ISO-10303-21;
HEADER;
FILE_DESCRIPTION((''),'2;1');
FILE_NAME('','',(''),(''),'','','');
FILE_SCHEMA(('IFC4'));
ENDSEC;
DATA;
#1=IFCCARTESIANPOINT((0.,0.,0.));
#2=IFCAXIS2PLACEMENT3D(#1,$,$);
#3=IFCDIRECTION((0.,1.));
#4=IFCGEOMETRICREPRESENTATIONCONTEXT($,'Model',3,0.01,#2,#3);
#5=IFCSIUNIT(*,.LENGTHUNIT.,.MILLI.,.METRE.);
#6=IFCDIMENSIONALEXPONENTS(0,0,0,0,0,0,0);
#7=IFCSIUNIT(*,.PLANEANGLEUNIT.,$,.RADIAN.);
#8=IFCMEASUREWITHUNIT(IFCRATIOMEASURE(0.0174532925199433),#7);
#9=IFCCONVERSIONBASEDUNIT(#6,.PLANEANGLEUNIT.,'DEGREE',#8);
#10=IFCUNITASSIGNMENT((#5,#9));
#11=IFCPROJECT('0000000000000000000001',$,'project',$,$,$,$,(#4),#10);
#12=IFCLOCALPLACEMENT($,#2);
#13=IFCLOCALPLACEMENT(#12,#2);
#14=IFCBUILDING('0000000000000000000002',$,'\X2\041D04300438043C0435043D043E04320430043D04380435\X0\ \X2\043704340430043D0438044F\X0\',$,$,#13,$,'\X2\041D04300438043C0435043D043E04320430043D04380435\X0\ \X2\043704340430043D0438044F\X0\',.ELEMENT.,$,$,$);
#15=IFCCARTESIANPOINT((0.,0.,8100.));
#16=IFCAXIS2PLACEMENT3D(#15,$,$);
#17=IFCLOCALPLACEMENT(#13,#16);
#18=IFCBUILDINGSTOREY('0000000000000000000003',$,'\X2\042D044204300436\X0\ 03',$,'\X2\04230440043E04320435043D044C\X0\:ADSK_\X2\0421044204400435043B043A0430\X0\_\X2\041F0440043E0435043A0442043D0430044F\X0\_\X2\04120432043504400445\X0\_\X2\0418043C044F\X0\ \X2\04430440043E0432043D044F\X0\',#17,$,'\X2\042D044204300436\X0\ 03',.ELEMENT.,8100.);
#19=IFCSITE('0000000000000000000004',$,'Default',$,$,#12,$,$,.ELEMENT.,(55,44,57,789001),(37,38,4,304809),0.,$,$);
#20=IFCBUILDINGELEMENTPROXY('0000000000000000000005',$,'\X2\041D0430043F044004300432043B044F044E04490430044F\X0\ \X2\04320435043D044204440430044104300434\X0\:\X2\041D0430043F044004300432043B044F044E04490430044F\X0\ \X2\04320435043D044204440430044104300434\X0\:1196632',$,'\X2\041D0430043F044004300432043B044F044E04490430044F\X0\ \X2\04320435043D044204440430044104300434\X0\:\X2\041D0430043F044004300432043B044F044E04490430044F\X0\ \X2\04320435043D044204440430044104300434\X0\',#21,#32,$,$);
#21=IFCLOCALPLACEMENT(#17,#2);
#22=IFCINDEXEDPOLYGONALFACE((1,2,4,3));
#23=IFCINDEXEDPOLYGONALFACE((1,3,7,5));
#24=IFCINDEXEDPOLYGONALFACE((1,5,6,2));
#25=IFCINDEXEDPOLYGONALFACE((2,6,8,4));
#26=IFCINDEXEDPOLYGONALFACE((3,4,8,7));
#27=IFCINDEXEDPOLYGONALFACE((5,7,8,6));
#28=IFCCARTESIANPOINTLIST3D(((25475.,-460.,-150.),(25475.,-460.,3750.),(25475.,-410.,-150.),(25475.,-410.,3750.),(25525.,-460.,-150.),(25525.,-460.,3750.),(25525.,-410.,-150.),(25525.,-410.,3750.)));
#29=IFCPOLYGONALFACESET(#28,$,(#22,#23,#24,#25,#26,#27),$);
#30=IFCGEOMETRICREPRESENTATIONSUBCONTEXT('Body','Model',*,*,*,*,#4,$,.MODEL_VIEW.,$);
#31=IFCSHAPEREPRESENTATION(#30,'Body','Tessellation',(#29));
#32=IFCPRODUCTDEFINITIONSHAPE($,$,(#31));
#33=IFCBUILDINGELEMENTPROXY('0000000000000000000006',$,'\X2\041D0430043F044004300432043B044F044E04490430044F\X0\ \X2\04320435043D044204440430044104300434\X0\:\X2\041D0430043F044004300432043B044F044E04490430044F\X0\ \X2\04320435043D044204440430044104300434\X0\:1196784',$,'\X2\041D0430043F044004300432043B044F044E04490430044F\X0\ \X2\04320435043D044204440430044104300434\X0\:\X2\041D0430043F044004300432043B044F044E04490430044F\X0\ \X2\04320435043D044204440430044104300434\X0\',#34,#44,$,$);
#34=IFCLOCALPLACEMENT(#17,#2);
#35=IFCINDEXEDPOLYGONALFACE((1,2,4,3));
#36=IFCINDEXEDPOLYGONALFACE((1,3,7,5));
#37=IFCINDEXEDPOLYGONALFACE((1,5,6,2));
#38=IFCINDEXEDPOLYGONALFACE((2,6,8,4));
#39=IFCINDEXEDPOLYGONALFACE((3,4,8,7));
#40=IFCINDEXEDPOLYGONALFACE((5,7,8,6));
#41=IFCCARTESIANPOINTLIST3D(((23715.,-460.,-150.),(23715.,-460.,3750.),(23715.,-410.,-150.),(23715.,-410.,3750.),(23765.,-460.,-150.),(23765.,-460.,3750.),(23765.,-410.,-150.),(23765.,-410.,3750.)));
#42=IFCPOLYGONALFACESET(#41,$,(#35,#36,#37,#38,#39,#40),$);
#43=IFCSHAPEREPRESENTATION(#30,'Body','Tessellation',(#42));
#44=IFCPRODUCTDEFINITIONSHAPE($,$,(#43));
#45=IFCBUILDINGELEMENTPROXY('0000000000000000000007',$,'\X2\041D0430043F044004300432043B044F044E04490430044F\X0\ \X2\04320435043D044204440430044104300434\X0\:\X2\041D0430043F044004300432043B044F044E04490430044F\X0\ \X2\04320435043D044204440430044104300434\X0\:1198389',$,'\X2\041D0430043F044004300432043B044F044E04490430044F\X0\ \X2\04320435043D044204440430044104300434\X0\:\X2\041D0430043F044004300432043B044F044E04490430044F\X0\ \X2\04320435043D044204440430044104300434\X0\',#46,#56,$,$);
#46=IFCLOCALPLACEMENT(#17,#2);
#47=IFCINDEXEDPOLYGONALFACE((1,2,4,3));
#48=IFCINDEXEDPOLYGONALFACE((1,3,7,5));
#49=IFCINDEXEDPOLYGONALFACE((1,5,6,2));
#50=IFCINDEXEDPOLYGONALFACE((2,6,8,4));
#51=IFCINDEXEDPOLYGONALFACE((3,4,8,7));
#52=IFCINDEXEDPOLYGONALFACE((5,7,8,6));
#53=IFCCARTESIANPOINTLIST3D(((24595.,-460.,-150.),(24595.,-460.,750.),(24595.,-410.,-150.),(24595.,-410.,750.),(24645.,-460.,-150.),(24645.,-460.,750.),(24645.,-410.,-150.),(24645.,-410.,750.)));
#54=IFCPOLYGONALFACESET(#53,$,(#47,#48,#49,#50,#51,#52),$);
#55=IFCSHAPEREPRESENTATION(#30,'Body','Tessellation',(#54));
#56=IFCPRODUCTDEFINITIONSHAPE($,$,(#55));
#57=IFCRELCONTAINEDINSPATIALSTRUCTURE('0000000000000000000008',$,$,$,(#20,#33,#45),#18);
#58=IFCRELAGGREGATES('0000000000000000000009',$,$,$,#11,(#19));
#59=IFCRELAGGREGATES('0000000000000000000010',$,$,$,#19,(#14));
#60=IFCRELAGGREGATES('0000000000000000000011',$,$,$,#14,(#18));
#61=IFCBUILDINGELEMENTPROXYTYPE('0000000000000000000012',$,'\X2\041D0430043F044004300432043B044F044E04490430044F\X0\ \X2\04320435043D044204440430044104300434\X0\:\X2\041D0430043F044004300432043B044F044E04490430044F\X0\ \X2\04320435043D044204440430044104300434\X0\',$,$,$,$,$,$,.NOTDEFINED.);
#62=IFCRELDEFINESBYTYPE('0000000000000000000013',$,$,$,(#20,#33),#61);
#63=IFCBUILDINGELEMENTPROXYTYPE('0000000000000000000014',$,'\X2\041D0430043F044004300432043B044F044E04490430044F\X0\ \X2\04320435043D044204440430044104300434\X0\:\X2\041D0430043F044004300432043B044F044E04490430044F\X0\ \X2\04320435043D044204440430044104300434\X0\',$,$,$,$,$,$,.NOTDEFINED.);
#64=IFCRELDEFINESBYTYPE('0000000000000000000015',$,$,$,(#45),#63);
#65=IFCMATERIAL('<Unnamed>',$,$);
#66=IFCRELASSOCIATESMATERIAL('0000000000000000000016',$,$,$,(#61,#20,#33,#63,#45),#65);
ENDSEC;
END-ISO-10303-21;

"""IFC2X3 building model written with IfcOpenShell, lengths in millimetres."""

from ifc_helpers import new_model, entity, si_unit, converted_unit, direction, frame, origin, origin_2d_with_axis, place, context, subcontext, project, spatial, rectangle, extrude, source, transform, mapped, material, type_object, type_shapes, element, save


model = new_model("IFC2X3")

# Units and contexts
model_context = context("Model", 3, precision=0.01, world=origin(), true_north=direction((0.0, 1.0)))
body_context = subcontext(model_context, "Body", "Model", "MODEL_VIEW")
ifc_project = project(units=[si_unit("LENGTHUNIT", "METRE", prefix="MILLI"), converted_unit("PLANEANGLEUNIT", "DEGREE", entity("IfcRatioMeasure", 0.0174532925199433), si_unit("PLANEANGLEUNIT", "RADIAN"), dimensions=[0, 0, 0, 0, 0, 0, 0])], contexts=[model_context])

# Site, building, storey
site_placement = place(None, origin())
site = spatial("IfcSite", under=ifc_project, at=site_placement, Name="Default", CompositionType="ELEMENT", RefLatitude=(55, 44, 57, 789001), RefLongitude=(37, 38, 4, 304809), RefElevation=0.0)
building_placement = place(site_placement, origin())
building = spatial("IfcBuilding", under=site, at=building_placement, Name="Наименование здания", LongName="Наименование здания", CompositionType="ELEMENT")
storey_placement = place(building_placement, frame((0.0, 0.0, 8100.0)))
storey = spatial("IfcBuildingStorey", under=building, at=storey_placement, Name="Этаж 03", ObjectType="Уровень:ADSK_Стрелка_Проектная_Вверх_Имя уровня", LongName="Этаж 03", CompositionType="ELEMENT", Elevation=8100.0)

# Building element proxies
ifc_material_1 = material(Name="<Unnamed>")
building_element_proxy_type_1 = type_object("IfcBuildingElementProxyType", Name="Направляющая вентфасад:Направляющая вентфасад", PredefinedType="NOTDEFINED", material=ifc_material_1)
shared_shape_1 = source(origin(), body_context, "Body", "SweptSolid", [
    extrude(rectangle(XDim=50.0, YDim=50.0, at=origin_2d_with_axis()), frame((25.0, -25.0, 0.0), z_axis=(0.0, 0.0, 1.0), x_axis=(-1.0, 0.0, 0.0)), (0.0, 0.0, 1.0), 3900.0),
])
type_shapes(building_element_proxy_type_1, [shared_shape_1])
for number, where, name in (
    (1, (25475.0, -410.0, -150.0), "Направляющая вентфасад:Направляющая вентфасад:1196632"),
    (2, (23715.0, -410.0, -150.0), "Направляющая вентфасад:Направляющая вентфасад:1196784"),
):
    element("IfcBuildingElementProxy", number, at=place(storey_placement, frame(where)), inside=storey, type_object=building_element_proxy_type_1, material=ifc_material_1, Name=name, ObjectType="Направляющая вентфасад:Направляющая вентфасад", context=body_context, shape_type="MappedRepresentation", body=[
        mapped(shared_shape_1, transform((0.0, 0.0, 0.0), scale=1.0)),
    ])
building_element_proxy_type_2 = type_object("IfcBuildingElementProxyType", Name="Направляющая вентфасад:Направляющая вентфасад", PredefinedType="NOTDEFINED", material=ifc_material_1)
shared_shape_2 = source(origin(), body_context, "Body", "SweptSolid", [
    extrude(rectangle(XDim=50.0, YDim=50.0, at=origin_2d_with_axis()), frame((25.0, -25.0, 0.0), z_axis=(0.0, 0.0, 1.0), x_axis=(-1.0, 0.0, 0.0)), (0.0, 0.0, 1.0), 900.0),
])
type_shapes(building_element_proxy_type_2, [shared_shape_2])
proxy_1_placement = place(storey_placement, frame((24595.0, -410.0, -150.0)))
element("IfcBuildingElementProxy", 3, at=proxy_1_placement, inside=storey, type_object=building_element_proxy_type_2, material=ifc_material_1, Name="Направляющая вентфасад:Направляющая вентфасад:1198389", ObjectType="Направляющая вентфасад:Направляющая вентфасад", context=body_context, shape_type="MappedRepresentation", body=[
    mapped(shared_shape_2, transform((0.0, 0.0, 0.0), scale=1.0)),
])

save(model, "model.ifc")
